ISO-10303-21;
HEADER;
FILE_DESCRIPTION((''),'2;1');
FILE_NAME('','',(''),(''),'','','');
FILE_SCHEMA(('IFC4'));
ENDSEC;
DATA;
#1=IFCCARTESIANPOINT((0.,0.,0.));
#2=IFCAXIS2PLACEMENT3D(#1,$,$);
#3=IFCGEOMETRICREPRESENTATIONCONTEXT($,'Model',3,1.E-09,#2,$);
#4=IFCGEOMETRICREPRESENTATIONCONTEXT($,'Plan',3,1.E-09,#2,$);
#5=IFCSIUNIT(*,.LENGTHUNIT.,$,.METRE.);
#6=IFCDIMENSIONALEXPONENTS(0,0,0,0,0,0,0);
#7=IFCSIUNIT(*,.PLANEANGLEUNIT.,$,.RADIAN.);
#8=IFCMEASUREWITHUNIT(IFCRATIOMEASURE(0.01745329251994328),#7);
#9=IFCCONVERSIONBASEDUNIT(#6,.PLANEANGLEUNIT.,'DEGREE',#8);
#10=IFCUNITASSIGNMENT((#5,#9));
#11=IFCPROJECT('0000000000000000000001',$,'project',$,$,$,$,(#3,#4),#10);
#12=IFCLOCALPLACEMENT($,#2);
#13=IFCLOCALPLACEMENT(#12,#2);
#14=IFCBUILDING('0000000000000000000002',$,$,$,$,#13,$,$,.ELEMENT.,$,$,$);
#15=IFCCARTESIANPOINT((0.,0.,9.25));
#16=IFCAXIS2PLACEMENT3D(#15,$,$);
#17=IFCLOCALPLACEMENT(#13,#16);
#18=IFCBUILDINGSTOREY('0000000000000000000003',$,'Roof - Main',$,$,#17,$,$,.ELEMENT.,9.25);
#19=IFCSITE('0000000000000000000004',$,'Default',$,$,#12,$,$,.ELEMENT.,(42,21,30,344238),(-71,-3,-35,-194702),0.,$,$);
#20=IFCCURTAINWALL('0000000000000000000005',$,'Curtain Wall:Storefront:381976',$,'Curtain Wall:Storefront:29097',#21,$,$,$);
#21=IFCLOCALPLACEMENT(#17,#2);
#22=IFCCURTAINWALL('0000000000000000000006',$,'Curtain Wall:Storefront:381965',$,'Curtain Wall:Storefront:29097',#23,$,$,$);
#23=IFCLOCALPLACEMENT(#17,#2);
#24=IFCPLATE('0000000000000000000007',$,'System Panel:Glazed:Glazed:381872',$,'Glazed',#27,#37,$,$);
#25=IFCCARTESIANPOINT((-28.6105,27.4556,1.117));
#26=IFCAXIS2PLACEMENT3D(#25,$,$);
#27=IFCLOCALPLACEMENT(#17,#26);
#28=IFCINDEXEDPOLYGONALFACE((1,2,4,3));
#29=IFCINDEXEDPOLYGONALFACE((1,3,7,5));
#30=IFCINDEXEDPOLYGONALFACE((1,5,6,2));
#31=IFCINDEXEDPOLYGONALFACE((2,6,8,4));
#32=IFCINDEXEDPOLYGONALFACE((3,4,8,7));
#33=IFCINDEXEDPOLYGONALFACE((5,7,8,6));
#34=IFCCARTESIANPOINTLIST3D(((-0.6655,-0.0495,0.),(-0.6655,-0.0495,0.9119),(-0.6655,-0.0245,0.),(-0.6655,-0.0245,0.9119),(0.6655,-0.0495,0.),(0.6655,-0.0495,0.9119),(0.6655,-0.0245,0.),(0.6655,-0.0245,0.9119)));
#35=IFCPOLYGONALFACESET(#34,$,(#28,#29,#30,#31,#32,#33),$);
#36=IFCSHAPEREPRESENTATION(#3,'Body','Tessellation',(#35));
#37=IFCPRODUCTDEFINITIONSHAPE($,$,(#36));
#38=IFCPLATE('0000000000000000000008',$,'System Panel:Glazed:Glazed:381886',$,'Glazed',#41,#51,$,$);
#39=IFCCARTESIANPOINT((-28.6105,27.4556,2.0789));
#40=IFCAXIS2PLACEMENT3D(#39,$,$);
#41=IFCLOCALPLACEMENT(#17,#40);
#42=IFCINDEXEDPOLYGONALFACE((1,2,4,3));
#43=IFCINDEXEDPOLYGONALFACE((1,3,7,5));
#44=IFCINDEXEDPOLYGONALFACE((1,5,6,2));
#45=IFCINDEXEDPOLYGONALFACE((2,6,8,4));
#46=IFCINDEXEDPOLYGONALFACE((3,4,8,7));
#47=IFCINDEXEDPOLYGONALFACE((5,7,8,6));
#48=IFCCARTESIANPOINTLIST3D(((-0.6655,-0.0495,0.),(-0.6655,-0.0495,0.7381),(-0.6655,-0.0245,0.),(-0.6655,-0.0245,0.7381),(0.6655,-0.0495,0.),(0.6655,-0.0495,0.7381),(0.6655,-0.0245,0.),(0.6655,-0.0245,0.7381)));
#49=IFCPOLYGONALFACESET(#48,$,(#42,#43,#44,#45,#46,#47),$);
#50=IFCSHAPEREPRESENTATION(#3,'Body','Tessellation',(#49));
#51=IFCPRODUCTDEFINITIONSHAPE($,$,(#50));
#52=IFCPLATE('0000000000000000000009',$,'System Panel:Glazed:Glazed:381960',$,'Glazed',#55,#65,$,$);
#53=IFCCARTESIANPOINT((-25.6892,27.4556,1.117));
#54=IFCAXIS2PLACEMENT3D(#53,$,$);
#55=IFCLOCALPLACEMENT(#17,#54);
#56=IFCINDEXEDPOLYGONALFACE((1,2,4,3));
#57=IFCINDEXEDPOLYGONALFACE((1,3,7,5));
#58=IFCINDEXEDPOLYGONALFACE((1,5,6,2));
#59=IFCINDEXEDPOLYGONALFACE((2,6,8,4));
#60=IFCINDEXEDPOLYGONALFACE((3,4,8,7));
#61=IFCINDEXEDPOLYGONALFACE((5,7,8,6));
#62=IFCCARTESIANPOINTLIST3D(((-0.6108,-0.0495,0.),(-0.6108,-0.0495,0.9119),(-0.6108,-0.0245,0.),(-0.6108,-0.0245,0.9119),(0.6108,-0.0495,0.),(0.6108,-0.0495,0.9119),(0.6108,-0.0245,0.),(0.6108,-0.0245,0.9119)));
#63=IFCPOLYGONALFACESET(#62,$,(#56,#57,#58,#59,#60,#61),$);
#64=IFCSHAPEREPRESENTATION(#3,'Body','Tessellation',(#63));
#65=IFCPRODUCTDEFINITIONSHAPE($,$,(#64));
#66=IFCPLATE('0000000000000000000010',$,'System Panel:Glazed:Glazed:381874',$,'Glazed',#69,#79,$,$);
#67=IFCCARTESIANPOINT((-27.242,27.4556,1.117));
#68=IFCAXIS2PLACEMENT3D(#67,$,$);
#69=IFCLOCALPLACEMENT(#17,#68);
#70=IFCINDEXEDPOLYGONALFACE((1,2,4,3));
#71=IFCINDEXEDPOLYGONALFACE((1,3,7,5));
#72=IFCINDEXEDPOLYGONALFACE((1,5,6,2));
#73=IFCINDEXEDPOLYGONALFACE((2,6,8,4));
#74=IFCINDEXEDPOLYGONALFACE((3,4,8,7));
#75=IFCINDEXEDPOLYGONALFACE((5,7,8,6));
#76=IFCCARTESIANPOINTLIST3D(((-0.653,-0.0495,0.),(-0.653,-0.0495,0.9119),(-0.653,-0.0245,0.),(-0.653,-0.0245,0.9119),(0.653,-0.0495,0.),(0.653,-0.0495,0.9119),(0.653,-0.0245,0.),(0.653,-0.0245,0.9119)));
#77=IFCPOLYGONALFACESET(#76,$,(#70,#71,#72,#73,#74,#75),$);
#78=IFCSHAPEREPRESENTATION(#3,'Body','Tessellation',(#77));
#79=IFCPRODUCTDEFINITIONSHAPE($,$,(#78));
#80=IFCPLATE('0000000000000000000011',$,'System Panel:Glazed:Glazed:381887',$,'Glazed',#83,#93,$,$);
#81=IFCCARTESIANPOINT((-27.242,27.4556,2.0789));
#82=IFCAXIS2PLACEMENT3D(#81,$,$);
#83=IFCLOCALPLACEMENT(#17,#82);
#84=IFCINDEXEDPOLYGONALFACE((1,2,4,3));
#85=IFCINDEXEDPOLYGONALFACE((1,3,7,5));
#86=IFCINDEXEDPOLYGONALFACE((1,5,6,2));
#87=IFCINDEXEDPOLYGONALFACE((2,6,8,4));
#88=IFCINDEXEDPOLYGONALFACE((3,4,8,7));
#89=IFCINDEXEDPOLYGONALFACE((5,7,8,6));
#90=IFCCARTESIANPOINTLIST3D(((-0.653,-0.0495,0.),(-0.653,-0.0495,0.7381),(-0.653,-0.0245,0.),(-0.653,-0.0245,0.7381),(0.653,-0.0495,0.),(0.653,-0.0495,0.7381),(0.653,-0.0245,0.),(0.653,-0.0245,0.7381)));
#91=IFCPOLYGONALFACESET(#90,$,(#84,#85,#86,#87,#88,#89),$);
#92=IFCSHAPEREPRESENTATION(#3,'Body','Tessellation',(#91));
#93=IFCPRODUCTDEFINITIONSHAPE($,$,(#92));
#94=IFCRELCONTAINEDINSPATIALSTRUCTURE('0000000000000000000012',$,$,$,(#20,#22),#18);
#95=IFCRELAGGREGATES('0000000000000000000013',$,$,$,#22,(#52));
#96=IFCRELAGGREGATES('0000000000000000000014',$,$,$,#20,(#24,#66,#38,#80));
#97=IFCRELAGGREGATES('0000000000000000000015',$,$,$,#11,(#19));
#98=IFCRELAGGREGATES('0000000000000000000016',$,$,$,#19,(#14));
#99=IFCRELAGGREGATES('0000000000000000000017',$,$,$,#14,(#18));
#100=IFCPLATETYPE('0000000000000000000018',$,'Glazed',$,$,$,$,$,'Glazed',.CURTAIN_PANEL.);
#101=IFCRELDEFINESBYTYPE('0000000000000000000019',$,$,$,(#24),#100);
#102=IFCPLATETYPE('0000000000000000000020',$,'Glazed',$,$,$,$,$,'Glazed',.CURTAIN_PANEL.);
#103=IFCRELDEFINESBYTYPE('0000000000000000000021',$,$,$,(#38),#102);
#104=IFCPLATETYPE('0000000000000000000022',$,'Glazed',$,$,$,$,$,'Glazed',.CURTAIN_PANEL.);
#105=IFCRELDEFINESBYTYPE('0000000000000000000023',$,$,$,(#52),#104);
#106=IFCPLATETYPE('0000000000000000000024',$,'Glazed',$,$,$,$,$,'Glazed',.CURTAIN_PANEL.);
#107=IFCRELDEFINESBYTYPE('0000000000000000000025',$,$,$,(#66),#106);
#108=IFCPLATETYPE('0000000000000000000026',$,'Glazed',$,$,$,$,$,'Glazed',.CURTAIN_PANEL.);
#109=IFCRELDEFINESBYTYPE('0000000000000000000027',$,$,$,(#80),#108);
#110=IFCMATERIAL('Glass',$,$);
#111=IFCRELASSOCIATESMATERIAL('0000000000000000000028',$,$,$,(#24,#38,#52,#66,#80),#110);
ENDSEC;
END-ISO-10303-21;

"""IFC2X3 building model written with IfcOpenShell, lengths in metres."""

from ifc_helpers import new_model, entity, si_unit, converted_unit, frame, origin, origin_2d_with_axis, place, context, project, spatial, rectangle, extrude, source, transform, mapped, material, type_object, type_shapes, element, aggregate, save


model = new_model("IFC2X3")

# Units and contexts
model_context = context("Model", 3, precision=1e-09, world=origin())
plan_context = context("Plan", 3, precision=1e-09, world=origin())
ifc_project = project(units=[si_unit("LENGTHUNIT", "METRE"), converted_unit("PLANEANGLEUNIT", "DEGREE", entity("IfcRatioMeasure", 0.01745329251994328), si_unit("PLANEANGLEUNIT", "RADIAN"), dimensions=[0, 0, 0, 0, 0, 0, 0])], contexts=[model_context, plan_context])

# Site, building, storey
site_placement = place(None, origin())
site = spatial("IfcSite", under=ifc_project, at=site_placement, Name="Default", CompositionType="ELEMENT", RefLatitude=(42, 21, 30, 344238), RefLongitude=(-71, -3, -35, -194702), RefElevation=0.0)
building_placement = place(site_placement, origin())
building = spatial("IfcBuilding", under=site, at=building_placement, CompositionType="ELEMENT")
storey_placement = place(building_placement, frame((0.0, 0.0, 9.25)))
storey = spatial("IfcBuildingStorey", under=building, at=storey_placement, Name="Roof - Main", CompositionType="ELEMENT", Elevation=9.25)

# Curtain walls
curtain_wall_1_placement = place(storey_placement, origin())
curtain_wall_1 = element("IfcCurtainWall", 1, at=curtain_wall_1_placement, inside=storey, Name="Curtain Wall:Storefront:381976", ObjectType="Curtain Wall:Storefront:29097")
curtain_wall_2_placement = place(storey_placement, origin())
curtain_wall_2 = element("IfcCurtainWall", 2, at=curtain_wall_2_placement, inside=storey, Name="Curtain Wall:Storefront:381965", ObjectType="Curtain Wall:Storefront:29097")

# Plates
ifc_material_1 = material(Name="Glass")
plate_type_1 = type_object("IfcPlateType", Name="Glazed", ElementType="Glazed", PredefinedType="CURTAIN_PANEL")
shared_shape_1 = source(origin(), model_context, "Body", "SweptSolid", [
    extrude(rectangle(XDim=0.025, YDim=1.331, at=origin_2d_with_axis()), frame((0.0, -0.037, 0.0), z_axis=(0.0, 0.0, 1.0), x_axis=(0.0, 1.0, 0.0)), (0.0, 0.0, 1.0), 0.9119),
])
type_shapes(plate_type_1, [shared_shape_1])
plate_1_placement = place(storey_placement, frame((-28.6105, 27.4556, 1.117)))
plate_1 = element("IfcPlate", 3, at=plate_1_placement, type_object=plate_type_1, material=ifc_material_1, Name="System Panel:Glazed:Glazed:381872", ObjectType="Glazed", context=model_context, shape_type="MappedRepresentation", body=[
    mapped(shared_shape_1, transform((0.0, 0.0, 0.0), scale=1.0)),
])
plate_type_2 = type_object("IfcPlateType", Name="Glazed", ElementType="Glazed", PredefinedType="CURTAIN_PANEL")
shared_shape_2 = source(origin(), model_context, "Body", "SweptSolid", [
    extrude(rectangle(XDim=0.025, YDim=1.331, at=origin_2d_with_axis()), frame((0.0, -0.037, 0.0), z_axis=(0.0, 0.0, 1.0), x_axis=(0.0, 1.0, 0.0)), (0.0, 0.0, 1.0), 0.7381),
])
type_shapes(plate_type_2, [shared_shape_2])
plate_2_placement = place(storey_placement, frame((-28.6105, 27.4556, 2.0789)))
plate_2 = element("IfcPlate", 4, at=plate_2_placement, type_object=plate_type_2, material=ifc_material_1, Name="System Panel:Glazed:Glazed:381886", ObjectType="Glazed", context=model_context, shape_type="MappedRepresentation", body=[
    mapped(shared_shape_2, transform((0.0, 0.0, 0.0), scale=1.0)),
])
plate_type_3 = type_object("IfcPlateType", Name="Glazed", ElementType="Glazed", PredefinedType="CURTAIN_PANEL")
shared_shape_3 = source(origin(), model_context, "Body", "SweptSolid", [
    extrude(rectangle(XDim=0.025, YDim=1.2217, at=origin_2d_with_axis()), frame((0.0, -0.037, 0.0), z_axis=(0.0, 0.0, 1.0), x_axis=(0.0, 1.0, 0.0)), (0.0, 0.0, 1.0), 0.9119),
])
type_shapes(plate_type_3, [shared_shape_3])
plate_3_placement = place(storey_placement, frame((-25.6892, 27.4556, 1.117)))
plate_3 = element("IfcPlate", 5, at=plate_3_placement, type_object=plate_type_3, material=ifc_material_1, Name="System Panel:Glazed:Glazed:381960", ObjectType="Glazed", context=model_context, shape_type="MappedRepresentation", body=[
    mapped(shared_shape_3, transform((0.0, 0.0, 0.0), scale=1.0)),
])
aggregate(curtain_wall_2, [plate_3])
plate_type_4 = type_object("IfcPlateType", Name="Glazed", ElementType="Glazed", PredefinedType="CURTAIN_PANEL")
shared_shape_4 = source(origin(), model_context, "Body", "SweptSolid", [
    extrude(rectangle(XDim=0.025, YDim=1.306, at=origin_2d_with_axis()), frame((0.0, -0.037, 0.0), z_axis=(0.0, 0.0, 1.0), x_axis=(0.0, 1.0, 0.0)), (0.0, 0.0, 1.0), 0.9119),
])
type_shapes(plate_type_4, [shared_shape_4])
plate_4_placement = place(storey_placement, frame((-27.242, 27.4556, 1.117)))
plate_4 = element("IfcPlate", 6, at=plate_4_placement, type_object=plate_type_4, material=ifc_material_1, Name="System Panel:Glazed:Glazed:381874", ObjectType="Glazed", context=model_context, shape_type="MappedRepresentation", body=[
    mapped(shared_shape_4, transform((0.0, 0.0, 0.0), scale=1.0)),
])
plate_type_5 = type_object("IfcPlateType", Name="Glazed", ElementType="Glazed", PredefinedType="CURTAIN_PANEL")
shared_shape_5 = source(origin(), model_context, "Body", "SweptSolid", [
    extrude(rectangle(XDim=0.025, YDim=1.306, at=origin_2d_with_axis()), frame((0.0, -0.037, 0.0), z_axis=(0.0, 0.0, 1.0), x_axis=(0.0, 1.0, 0.0)), (0.0, 0.0, 1.0), 0.7381),
])
type_shapes(plate_type_5, [shared_shape_5])
plate_5_placement = place(storey_placement, frame((-27.242, 27.4556, 2.0789)))
plate_5 = element("IfcPlate", 7, at=plate_5_placement, type_object=plate_type_5, material=ifc_material_1, Name="System Panel:Glazed:Glazed:381887", ObjectType="Glazed", context=model_context, shape_type="MappedRepresentation", body=[
    mapped(shared_shape_5, transform((0.0, 0.0, 0.0), scale=1.0)),
])
aggregate(curtain_wall_1, [plate_1, plate_4, plate_2, plate_5])

save(model, "model.ifc")
